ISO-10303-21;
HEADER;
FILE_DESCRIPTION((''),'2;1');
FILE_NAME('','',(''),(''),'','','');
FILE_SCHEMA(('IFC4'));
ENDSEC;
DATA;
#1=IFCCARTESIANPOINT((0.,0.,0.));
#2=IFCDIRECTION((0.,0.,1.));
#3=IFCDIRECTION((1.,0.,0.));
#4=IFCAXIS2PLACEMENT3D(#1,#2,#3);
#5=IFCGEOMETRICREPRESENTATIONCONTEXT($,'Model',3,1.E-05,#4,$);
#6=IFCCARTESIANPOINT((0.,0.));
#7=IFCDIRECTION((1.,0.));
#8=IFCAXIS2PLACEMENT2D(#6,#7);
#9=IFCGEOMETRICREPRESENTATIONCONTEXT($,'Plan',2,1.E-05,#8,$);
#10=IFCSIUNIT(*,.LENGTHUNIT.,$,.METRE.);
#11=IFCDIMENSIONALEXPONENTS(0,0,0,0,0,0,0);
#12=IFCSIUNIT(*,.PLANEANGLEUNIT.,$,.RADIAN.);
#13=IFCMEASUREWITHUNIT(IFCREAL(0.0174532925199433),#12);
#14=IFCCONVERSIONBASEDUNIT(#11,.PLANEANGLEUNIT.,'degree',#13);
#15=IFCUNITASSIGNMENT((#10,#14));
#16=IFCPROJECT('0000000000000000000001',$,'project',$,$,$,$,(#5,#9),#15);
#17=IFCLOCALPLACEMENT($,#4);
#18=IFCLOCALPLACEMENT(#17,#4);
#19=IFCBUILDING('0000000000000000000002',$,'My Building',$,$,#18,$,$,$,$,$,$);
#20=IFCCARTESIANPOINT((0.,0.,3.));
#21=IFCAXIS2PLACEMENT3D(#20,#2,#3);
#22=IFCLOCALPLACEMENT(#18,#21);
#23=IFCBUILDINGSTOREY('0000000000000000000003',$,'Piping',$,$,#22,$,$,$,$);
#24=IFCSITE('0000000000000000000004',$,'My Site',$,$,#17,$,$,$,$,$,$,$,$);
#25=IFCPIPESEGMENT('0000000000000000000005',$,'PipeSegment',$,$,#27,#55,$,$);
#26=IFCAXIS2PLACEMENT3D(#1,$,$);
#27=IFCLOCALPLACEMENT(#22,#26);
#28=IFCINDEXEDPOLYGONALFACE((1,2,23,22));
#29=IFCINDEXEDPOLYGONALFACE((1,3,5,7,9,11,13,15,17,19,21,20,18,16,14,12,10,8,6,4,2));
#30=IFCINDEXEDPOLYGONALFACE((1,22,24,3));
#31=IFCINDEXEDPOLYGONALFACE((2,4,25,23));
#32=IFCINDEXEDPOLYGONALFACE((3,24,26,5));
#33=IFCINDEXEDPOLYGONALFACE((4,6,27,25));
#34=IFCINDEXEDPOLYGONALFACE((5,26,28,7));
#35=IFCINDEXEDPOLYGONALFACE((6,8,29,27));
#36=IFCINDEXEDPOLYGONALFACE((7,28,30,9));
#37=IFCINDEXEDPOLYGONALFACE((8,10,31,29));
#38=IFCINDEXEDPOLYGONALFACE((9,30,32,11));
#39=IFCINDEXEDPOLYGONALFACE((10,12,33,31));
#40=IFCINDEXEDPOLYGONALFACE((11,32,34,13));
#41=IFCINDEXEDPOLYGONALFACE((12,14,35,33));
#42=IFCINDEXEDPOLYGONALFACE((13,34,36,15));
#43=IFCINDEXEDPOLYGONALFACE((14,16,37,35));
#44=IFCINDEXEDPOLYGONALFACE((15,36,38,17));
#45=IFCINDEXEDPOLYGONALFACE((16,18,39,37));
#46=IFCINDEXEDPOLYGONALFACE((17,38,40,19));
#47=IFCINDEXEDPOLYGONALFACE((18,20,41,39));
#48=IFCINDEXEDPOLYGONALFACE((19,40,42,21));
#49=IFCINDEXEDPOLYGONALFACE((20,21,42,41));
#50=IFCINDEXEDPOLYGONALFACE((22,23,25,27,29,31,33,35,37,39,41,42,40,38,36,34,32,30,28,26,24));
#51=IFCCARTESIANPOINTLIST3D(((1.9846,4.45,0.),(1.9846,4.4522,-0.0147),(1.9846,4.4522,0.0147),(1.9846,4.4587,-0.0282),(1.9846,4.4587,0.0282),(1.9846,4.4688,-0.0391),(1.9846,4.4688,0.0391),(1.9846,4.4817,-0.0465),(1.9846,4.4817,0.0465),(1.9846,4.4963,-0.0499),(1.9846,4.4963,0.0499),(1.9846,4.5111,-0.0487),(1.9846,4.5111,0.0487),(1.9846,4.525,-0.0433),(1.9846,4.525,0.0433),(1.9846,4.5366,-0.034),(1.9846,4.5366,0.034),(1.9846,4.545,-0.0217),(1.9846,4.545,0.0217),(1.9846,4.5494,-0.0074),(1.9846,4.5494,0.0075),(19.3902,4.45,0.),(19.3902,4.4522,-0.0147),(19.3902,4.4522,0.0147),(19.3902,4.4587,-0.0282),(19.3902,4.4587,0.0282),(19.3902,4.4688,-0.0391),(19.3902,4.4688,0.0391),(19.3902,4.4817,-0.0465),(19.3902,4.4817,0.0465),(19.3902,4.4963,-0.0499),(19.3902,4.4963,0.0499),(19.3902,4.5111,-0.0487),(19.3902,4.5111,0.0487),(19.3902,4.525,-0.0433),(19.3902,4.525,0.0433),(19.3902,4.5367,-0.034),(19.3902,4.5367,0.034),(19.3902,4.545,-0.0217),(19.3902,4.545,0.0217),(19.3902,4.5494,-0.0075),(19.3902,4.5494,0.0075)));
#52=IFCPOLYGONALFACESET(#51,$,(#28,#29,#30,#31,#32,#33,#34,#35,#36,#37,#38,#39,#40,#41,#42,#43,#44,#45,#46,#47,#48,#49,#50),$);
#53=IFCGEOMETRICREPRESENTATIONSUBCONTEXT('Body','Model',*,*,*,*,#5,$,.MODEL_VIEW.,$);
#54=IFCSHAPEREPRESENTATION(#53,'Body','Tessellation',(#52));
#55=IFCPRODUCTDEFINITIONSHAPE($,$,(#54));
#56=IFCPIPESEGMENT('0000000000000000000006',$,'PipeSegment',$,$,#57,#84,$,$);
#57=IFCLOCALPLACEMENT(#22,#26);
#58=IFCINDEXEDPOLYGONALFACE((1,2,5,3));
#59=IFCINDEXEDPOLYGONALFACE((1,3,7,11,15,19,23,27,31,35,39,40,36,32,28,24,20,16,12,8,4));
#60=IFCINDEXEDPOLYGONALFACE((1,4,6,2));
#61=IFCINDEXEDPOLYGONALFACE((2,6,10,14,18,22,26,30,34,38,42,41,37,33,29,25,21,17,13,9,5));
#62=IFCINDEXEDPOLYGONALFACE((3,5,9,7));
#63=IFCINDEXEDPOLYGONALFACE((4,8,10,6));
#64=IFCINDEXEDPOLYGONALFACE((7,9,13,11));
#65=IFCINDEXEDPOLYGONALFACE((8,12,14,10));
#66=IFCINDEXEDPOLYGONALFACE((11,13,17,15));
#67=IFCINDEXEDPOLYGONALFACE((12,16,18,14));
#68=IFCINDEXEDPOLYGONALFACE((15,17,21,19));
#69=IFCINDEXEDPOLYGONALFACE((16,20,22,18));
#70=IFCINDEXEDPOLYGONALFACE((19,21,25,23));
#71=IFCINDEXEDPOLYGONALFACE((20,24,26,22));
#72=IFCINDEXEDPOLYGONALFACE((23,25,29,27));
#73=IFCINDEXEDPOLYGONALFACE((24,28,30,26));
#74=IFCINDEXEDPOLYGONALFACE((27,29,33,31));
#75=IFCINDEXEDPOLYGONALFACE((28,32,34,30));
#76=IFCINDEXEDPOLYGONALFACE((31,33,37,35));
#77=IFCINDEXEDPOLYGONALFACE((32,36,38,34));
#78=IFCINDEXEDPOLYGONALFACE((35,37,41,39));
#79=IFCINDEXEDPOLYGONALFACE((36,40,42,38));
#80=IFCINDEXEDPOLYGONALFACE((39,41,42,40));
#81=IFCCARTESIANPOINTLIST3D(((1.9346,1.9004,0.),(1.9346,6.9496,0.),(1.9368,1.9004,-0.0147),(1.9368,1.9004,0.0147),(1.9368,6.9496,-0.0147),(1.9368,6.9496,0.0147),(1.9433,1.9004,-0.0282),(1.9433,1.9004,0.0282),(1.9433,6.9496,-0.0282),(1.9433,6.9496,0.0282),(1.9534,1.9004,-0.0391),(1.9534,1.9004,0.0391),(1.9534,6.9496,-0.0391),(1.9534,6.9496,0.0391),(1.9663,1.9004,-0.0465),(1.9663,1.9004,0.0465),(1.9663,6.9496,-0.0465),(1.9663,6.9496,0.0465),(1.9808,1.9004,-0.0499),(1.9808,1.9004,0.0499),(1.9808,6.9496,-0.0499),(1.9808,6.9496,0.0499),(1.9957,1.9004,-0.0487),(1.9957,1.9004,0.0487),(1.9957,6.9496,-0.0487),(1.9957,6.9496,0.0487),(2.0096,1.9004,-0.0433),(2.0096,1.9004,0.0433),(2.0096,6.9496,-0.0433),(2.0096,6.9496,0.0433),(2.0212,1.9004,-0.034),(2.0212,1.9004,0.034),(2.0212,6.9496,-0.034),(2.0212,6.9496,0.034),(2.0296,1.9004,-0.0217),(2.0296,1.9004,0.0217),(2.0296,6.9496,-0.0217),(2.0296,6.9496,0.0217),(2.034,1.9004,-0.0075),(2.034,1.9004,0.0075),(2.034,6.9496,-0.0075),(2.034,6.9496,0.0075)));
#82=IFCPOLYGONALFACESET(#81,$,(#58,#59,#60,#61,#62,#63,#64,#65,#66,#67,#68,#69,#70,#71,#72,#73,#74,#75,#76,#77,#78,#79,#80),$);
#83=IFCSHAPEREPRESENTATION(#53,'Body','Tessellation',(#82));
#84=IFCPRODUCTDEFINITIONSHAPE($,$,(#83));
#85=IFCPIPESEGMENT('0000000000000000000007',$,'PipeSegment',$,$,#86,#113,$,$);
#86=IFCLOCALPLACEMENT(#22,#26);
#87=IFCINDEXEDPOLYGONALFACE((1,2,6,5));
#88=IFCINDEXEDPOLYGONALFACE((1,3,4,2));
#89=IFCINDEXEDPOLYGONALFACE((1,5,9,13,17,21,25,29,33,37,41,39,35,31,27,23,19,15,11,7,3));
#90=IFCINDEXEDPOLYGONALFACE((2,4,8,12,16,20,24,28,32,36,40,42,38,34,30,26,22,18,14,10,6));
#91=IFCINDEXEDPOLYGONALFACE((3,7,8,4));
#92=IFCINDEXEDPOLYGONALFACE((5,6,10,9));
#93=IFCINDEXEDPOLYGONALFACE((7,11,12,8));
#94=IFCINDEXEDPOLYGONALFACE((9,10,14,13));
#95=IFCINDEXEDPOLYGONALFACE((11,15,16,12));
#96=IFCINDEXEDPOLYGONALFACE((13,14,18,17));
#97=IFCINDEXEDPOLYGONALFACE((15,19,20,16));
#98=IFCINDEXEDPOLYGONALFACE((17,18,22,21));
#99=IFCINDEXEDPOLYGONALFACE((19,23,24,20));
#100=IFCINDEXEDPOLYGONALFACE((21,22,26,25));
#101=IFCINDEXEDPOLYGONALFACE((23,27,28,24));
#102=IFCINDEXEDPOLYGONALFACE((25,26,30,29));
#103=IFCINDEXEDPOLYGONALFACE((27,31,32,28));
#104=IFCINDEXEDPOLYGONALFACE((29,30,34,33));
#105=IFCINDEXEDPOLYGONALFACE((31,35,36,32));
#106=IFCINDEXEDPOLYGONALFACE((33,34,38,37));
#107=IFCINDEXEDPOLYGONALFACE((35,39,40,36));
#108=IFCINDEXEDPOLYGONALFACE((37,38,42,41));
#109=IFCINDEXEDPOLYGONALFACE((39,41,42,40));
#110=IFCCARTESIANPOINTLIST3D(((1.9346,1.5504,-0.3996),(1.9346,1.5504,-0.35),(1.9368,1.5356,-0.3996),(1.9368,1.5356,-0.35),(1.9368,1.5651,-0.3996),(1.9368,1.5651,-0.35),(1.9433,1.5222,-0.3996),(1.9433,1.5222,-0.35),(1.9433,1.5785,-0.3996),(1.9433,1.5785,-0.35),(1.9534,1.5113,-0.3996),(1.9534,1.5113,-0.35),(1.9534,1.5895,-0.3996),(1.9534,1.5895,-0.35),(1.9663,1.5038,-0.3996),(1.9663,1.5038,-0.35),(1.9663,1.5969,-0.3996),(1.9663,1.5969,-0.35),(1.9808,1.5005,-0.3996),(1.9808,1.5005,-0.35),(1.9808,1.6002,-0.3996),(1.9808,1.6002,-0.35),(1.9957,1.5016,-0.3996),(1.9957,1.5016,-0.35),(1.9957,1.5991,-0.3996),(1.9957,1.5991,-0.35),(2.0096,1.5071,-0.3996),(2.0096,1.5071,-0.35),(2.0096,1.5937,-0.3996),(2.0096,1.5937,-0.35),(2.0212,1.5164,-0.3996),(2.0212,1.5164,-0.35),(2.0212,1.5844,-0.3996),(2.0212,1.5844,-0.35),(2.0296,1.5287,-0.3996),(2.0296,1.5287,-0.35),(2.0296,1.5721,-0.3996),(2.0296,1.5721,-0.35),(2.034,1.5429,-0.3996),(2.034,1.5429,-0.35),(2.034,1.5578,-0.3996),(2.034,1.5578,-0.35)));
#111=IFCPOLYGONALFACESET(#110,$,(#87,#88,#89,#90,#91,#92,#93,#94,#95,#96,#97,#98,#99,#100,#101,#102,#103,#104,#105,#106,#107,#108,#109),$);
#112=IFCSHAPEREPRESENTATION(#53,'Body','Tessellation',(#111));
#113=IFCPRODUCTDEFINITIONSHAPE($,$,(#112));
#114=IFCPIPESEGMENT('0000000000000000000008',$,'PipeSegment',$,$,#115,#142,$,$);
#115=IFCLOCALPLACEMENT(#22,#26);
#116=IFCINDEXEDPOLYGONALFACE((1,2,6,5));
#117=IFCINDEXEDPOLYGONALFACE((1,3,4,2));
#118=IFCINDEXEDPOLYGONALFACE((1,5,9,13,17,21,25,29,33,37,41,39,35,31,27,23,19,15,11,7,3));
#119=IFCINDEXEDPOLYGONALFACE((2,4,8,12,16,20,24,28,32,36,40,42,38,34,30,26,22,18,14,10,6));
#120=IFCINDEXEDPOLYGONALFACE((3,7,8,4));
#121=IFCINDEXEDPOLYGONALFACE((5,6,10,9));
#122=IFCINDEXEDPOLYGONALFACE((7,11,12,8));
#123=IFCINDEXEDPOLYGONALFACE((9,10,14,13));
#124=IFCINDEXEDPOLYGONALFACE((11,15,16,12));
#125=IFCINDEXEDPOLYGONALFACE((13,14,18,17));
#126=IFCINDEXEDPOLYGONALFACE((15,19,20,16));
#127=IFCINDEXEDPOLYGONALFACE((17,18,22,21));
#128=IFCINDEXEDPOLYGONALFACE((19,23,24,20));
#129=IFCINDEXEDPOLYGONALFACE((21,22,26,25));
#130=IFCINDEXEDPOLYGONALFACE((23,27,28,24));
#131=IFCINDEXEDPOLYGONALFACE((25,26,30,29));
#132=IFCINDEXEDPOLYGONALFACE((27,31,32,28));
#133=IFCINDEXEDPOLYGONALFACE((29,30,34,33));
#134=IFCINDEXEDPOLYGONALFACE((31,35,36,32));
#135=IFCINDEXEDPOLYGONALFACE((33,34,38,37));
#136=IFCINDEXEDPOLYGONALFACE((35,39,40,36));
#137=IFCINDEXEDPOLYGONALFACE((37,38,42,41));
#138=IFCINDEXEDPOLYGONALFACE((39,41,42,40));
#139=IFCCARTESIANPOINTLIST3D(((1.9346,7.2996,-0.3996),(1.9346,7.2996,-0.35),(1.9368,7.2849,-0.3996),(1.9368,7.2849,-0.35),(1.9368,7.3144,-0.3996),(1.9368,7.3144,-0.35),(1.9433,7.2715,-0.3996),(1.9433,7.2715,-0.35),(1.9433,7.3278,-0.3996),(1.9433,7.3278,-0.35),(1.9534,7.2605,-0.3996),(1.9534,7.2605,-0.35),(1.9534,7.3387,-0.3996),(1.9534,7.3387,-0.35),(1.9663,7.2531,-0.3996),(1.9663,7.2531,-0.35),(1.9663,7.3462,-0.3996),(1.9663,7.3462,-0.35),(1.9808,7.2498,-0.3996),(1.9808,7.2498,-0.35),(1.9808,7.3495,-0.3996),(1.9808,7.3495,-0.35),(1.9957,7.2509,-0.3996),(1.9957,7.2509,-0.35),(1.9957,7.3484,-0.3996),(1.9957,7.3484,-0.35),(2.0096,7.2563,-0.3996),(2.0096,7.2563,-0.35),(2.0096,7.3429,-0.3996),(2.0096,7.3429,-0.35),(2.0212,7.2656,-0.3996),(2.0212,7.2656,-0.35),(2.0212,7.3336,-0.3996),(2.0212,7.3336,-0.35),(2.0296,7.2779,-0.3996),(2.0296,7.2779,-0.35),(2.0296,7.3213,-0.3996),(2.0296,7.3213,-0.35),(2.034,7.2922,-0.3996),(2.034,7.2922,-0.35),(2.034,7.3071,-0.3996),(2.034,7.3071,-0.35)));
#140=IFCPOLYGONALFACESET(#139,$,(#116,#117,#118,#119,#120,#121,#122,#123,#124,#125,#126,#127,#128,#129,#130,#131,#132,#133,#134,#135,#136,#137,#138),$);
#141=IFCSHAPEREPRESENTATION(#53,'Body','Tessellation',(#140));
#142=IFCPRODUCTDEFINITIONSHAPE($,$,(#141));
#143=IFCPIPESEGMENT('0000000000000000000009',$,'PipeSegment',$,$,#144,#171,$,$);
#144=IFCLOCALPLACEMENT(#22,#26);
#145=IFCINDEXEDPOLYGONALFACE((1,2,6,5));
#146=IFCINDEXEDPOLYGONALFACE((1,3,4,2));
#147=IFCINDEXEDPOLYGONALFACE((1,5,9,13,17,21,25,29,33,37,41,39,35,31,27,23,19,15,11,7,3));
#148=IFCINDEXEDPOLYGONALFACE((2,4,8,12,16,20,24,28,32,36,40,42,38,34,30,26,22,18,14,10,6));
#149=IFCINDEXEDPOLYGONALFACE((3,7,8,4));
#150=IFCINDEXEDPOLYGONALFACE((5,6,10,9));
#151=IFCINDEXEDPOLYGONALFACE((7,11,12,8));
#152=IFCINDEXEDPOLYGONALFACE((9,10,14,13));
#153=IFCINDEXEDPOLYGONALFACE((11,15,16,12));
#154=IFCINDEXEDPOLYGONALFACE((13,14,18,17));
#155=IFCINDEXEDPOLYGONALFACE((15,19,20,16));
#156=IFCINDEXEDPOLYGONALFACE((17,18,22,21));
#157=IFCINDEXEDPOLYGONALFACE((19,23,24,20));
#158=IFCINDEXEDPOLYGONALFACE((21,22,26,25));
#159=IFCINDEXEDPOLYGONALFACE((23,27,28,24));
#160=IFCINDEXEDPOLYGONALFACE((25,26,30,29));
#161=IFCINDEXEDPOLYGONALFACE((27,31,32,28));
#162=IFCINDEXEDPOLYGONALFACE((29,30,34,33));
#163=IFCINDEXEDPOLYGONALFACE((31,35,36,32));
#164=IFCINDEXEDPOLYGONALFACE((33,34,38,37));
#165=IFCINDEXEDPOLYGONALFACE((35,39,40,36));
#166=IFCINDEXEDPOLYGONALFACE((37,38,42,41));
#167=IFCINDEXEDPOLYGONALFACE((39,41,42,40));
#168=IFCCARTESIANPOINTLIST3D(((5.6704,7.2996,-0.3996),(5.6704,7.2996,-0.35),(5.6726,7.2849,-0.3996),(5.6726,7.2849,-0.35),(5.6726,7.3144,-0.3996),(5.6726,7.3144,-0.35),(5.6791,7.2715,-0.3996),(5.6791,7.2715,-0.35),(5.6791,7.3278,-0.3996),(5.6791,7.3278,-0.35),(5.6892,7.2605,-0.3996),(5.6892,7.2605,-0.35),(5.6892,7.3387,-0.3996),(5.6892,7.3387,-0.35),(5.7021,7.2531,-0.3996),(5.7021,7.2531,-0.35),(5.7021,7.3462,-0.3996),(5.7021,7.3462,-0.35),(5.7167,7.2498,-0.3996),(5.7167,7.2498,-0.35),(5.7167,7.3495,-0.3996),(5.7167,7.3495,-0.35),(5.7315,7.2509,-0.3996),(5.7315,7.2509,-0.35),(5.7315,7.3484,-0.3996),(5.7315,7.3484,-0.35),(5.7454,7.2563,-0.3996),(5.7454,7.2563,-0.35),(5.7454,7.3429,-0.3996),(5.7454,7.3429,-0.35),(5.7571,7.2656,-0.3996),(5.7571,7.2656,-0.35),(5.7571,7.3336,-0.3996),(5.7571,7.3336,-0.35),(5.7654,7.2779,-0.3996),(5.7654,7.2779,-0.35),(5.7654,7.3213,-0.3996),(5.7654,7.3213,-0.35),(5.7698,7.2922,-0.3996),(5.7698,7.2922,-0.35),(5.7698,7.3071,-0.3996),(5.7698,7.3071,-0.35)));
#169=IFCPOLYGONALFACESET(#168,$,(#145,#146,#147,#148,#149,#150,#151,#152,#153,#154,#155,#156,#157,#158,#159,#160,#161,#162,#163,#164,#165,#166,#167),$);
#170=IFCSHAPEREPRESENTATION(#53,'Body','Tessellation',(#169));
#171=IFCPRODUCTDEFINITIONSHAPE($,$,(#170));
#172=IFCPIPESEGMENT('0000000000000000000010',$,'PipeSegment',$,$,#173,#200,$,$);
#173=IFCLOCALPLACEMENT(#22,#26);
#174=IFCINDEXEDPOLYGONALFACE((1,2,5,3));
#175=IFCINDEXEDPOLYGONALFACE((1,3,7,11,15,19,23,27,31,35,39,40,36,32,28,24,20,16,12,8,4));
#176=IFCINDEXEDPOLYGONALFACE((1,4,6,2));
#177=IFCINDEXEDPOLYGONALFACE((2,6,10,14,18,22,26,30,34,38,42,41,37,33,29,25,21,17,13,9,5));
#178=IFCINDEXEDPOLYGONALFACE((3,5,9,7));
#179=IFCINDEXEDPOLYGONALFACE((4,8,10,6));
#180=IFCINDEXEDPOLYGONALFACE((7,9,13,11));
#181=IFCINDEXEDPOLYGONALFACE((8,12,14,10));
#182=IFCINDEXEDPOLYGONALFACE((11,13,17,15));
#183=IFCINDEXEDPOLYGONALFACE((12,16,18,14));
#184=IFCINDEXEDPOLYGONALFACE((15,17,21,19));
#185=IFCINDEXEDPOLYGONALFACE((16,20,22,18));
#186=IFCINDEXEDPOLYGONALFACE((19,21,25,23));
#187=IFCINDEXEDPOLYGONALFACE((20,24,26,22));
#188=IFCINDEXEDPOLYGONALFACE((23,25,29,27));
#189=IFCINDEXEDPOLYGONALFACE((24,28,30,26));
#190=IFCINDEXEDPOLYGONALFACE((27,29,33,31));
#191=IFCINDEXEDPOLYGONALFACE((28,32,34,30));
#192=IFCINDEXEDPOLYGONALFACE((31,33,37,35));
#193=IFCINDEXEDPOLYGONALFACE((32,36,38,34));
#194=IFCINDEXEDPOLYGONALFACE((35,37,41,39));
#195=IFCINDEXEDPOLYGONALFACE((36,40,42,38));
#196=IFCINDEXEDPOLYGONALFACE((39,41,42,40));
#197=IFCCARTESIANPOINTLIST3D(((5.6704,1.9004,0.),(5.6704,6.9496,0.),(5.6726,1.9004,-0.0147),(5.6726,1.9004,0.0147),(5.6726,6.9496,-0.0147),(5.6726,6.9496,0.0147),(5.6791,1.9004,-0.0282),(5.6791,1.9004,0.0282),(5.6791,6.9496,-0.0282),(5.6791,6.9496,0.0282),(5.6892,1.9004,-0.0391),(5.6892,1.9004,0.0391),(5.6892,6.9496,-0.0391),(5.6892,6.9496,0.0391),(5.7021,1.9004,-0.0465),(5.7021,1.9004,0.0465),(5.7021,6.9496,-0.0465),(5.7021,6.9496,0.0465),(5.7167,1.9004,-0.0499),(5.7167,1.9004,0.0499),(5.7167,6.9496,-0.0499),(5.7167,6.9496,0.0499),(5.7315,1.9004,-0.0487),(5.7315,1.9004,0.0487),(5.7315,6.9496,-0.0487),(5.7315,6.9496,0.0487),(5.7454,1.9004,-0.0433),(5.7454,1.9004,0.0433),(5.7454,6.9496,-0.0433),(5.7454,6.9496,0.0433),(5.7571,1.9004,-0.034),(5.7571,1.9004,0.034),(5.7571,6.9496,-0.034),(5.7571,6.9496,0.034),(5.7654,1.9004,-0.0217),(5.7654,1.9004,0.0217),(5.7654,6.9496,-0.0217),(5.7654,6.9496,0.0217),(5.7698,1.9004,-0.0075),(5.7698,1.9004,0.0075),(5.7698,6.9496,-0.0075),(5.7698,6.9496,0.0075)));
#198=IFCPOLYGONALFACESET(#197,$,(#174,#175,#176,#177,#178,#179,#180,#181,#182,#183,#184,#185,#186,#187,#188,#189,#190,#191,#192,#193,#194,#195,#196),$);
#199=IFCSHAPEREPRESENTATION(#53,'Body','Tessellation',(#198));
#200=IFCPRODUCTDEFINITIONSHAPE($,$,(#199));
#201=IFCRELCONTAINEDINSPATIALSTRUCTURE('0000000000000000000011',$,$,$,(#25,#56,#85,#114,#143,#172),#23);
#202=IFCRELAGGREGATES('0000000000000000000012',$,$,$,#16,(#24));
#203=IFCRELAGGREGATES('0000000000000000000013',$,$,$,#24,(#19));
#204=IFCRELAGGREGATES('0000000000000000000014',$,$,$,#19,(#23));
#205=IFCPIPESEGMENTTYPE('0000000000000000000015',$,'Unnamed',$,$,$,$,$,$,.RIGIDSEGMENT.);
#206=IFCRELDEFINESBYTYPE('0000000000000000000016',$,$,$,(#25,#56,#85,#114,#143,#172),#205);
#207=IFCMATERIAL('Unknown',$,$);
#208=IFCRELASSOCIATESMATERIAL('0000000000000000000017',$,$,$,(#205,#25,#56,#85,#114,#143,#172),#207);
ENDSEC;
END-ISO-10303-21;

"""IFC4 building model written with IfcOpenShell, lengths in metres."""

from ifc_helpers import new_model, entity, si_unit, converted_unit, frame, origin_with_axes, origin_2d_with_axis, place, context, subcontext, project, spatial, circle, extrude, material, material_profile, profile_set, profile_usage, type_object, element, save


model = new_model("IFC4")

# Units and contexts
model_context = context("Model", 3, precision=1e-05, world=origin_with_axes())
plan_context = context("Plan", 2, precision=1e-05, world=origin_2d_with_axis())
body_context = subcontext(model_context, "Body", "Model", "MODEL_VIEW")
ifc_project = project(units=[si_unit("LENGTHUNIT", "METRE"), converted_unit("PLANEANGLEUNIT", "degree", entity("IfcReal", 0.0174532925199433), si_unit("PLANEANGLEUNIT", "RADIAN"), dimensions=[0, 0, 0, 0, 0, 0, 0])], contexts=[model_context, plan_context])

# Site, building, storey
site_placement = place(None, origin_with_axes())
site = spatial("IfcSite", under=ifc_project, at=site_placement, Name="My Site")
building_placement = place(site_placement, origin_with_axes())
building = spatial("IfcBuilding", under=site, at=building_placement, Name="My Building")
storey_placement = place(building_placement, frame((0.0, 0.0, 3.0), z_axis=(0.0, 0.0, 1.0), x_axis=(1.0, 0.0, 0.0)))
storey = spatial("IfcBuildingStorey", under=building, at=storey_placement, Name="Piping")

# Pipe segments
ifc_material = material(Name="Unknown")
ifc_material_profile = material_profile(ifc_material, circle(Radius=0.05))
ifc_profile_set = profile_set([ifc_material_profile])
ifc_profile_usage_1 = profile_usage(ifc_profile_set, cardinal=5)
pipe_segment_type = type_object("IfcPipeSegmentType", Name="Unnamed", PredefinedType="RIGIDSEGMENT", material=ifc_profile_set)
pipe_segment_1_placement = place(storey_placement, frame((19.3902, 4.5, 0.0), z_axis=(-1.0, 0.0, 0.0), x_axis=(0.0, -1.0, 0.0)))
element("IfcPipeSegment", 1, at=pipe_segment_1_placement, inside=storey, type_object=pipe_segment_type, material=ifc_profile_usage_1, Name="PipeSegment", context=body_context, shape_type="SweptSolid", body=[
    extrude(circle(Radius=0.05), origin_with_axes(), (0.0, 0.0, 1.0), 17.4056),
])
ifc_profile_usage_2 = profile_usage(ifc_profile_set, cardinal=5)
pipe_segment_2_placement = place(storey_placement, frame((1.9846, 1.9004, 0.0), z_axis=(0.0, 1.0, 0.0), x_axis=(-1.0, 0.0, 0.0)))
element("IfcPipeSegment", 2, at=pipe_segment_2_placement, inside=storey, type_object=pipe_segment_type, material=ifc_profile_usage_2, Name="PipeSegment", context=body_context, shape_type="SweptSolid", body=[
    extrude(circle(Radius=0.05), origin_with_axes(), (0.0, 0.0, 1.0), 5.0493),
])
ifc_profile_usage_3 = profile_usage(ifc_profile_set, cardinal=5)
pipe_segment_3_placement = place(storey_placement, frame((1.9846, 1.5504, -0.35), z_axis=(0.0, 0.0, -1.0), x_axis=(-1.0, 0.0, 0.0)))
element("IfcPipeSegment", 3, at=pipe_segment_3_placement, inside=storey, type_object=pipe_segment_type, material=ifc_profile_usage_3, Name="PipeSegment", context=body_context, shape_type="SweptSolid", body=[
    extrude(circle(Radius=0.05), origin_with_axes(), (0.0, 0.0, 1.0), 0.0496),
])
ifc_profile_usage_4 = profile_usage(ifc_profile_set, cardinal=5)
pipe_segment_4_placement = place(storey_placement, frame((1.9846, 7.2996, -0.35), z_axis=(0.0, 0.0, -1.0), x_axis=(-1.0, 0.0, 0.0)))
element("IfcPipeSegment", 4, at=pipe_segment_4_placement, inside=storey, type_object=pipe_segment_type, material=ifc_profile_usage_4, Name="PipeSegment", context=body_context, shape_type="SweptSolid", body=[
    extrude(circle(Radius=0.05), origin_with_axes(), (0.0, 0.0, 1.0), 0.0496),
])
ifc_profile_usage_5 = profile_usage(ifc_profile_set, cardinal=5)
pipe_segment_5_placement = place(storey_placement, frame((5.7204, 7.2996, -0.35), z_axis=(0.0, 0.0, -1.0), x_axis=(-1.0, 0.0, 0.0)))
element("IfcPipeSegment", 5, at=pipe_segment_5_placement, inside=storey, type_object=pipe_segment_type, material=ifc_profile_usage_5, Name="PipeSegment", context=body_context, shape_type="SweptSolid", body=[
    extrude(circle(Radius=0.05), origin_with_axes(), (0.0, 0.0, 1.0), 0.0496),
])
ifc_profile_usage_6 = profile_usage(ifc_profile_set, cardinal=5)
pipe_segment_6_placement = place(storey_placement, frame((5.7204, 1.9004, 0.0), z_axis=(0.0, 1.0, 0.0), x_axis=(-1.0, 0.0, 0.0)))
element("IfcPipeSegment", 6, at=pipe_segment_6_placement, inside=storey, type_object=pipe_segment_type, material=ifc_profile_usage_6, Name="PipeSegment", context=body_context, shape_type="SweptSolid", body=[
    extrude(circle(Radius=0.05), origin_with_axes(), (0.0, 0.0, 1.0), 5.0493),
])

save(model, "model.ifc")
